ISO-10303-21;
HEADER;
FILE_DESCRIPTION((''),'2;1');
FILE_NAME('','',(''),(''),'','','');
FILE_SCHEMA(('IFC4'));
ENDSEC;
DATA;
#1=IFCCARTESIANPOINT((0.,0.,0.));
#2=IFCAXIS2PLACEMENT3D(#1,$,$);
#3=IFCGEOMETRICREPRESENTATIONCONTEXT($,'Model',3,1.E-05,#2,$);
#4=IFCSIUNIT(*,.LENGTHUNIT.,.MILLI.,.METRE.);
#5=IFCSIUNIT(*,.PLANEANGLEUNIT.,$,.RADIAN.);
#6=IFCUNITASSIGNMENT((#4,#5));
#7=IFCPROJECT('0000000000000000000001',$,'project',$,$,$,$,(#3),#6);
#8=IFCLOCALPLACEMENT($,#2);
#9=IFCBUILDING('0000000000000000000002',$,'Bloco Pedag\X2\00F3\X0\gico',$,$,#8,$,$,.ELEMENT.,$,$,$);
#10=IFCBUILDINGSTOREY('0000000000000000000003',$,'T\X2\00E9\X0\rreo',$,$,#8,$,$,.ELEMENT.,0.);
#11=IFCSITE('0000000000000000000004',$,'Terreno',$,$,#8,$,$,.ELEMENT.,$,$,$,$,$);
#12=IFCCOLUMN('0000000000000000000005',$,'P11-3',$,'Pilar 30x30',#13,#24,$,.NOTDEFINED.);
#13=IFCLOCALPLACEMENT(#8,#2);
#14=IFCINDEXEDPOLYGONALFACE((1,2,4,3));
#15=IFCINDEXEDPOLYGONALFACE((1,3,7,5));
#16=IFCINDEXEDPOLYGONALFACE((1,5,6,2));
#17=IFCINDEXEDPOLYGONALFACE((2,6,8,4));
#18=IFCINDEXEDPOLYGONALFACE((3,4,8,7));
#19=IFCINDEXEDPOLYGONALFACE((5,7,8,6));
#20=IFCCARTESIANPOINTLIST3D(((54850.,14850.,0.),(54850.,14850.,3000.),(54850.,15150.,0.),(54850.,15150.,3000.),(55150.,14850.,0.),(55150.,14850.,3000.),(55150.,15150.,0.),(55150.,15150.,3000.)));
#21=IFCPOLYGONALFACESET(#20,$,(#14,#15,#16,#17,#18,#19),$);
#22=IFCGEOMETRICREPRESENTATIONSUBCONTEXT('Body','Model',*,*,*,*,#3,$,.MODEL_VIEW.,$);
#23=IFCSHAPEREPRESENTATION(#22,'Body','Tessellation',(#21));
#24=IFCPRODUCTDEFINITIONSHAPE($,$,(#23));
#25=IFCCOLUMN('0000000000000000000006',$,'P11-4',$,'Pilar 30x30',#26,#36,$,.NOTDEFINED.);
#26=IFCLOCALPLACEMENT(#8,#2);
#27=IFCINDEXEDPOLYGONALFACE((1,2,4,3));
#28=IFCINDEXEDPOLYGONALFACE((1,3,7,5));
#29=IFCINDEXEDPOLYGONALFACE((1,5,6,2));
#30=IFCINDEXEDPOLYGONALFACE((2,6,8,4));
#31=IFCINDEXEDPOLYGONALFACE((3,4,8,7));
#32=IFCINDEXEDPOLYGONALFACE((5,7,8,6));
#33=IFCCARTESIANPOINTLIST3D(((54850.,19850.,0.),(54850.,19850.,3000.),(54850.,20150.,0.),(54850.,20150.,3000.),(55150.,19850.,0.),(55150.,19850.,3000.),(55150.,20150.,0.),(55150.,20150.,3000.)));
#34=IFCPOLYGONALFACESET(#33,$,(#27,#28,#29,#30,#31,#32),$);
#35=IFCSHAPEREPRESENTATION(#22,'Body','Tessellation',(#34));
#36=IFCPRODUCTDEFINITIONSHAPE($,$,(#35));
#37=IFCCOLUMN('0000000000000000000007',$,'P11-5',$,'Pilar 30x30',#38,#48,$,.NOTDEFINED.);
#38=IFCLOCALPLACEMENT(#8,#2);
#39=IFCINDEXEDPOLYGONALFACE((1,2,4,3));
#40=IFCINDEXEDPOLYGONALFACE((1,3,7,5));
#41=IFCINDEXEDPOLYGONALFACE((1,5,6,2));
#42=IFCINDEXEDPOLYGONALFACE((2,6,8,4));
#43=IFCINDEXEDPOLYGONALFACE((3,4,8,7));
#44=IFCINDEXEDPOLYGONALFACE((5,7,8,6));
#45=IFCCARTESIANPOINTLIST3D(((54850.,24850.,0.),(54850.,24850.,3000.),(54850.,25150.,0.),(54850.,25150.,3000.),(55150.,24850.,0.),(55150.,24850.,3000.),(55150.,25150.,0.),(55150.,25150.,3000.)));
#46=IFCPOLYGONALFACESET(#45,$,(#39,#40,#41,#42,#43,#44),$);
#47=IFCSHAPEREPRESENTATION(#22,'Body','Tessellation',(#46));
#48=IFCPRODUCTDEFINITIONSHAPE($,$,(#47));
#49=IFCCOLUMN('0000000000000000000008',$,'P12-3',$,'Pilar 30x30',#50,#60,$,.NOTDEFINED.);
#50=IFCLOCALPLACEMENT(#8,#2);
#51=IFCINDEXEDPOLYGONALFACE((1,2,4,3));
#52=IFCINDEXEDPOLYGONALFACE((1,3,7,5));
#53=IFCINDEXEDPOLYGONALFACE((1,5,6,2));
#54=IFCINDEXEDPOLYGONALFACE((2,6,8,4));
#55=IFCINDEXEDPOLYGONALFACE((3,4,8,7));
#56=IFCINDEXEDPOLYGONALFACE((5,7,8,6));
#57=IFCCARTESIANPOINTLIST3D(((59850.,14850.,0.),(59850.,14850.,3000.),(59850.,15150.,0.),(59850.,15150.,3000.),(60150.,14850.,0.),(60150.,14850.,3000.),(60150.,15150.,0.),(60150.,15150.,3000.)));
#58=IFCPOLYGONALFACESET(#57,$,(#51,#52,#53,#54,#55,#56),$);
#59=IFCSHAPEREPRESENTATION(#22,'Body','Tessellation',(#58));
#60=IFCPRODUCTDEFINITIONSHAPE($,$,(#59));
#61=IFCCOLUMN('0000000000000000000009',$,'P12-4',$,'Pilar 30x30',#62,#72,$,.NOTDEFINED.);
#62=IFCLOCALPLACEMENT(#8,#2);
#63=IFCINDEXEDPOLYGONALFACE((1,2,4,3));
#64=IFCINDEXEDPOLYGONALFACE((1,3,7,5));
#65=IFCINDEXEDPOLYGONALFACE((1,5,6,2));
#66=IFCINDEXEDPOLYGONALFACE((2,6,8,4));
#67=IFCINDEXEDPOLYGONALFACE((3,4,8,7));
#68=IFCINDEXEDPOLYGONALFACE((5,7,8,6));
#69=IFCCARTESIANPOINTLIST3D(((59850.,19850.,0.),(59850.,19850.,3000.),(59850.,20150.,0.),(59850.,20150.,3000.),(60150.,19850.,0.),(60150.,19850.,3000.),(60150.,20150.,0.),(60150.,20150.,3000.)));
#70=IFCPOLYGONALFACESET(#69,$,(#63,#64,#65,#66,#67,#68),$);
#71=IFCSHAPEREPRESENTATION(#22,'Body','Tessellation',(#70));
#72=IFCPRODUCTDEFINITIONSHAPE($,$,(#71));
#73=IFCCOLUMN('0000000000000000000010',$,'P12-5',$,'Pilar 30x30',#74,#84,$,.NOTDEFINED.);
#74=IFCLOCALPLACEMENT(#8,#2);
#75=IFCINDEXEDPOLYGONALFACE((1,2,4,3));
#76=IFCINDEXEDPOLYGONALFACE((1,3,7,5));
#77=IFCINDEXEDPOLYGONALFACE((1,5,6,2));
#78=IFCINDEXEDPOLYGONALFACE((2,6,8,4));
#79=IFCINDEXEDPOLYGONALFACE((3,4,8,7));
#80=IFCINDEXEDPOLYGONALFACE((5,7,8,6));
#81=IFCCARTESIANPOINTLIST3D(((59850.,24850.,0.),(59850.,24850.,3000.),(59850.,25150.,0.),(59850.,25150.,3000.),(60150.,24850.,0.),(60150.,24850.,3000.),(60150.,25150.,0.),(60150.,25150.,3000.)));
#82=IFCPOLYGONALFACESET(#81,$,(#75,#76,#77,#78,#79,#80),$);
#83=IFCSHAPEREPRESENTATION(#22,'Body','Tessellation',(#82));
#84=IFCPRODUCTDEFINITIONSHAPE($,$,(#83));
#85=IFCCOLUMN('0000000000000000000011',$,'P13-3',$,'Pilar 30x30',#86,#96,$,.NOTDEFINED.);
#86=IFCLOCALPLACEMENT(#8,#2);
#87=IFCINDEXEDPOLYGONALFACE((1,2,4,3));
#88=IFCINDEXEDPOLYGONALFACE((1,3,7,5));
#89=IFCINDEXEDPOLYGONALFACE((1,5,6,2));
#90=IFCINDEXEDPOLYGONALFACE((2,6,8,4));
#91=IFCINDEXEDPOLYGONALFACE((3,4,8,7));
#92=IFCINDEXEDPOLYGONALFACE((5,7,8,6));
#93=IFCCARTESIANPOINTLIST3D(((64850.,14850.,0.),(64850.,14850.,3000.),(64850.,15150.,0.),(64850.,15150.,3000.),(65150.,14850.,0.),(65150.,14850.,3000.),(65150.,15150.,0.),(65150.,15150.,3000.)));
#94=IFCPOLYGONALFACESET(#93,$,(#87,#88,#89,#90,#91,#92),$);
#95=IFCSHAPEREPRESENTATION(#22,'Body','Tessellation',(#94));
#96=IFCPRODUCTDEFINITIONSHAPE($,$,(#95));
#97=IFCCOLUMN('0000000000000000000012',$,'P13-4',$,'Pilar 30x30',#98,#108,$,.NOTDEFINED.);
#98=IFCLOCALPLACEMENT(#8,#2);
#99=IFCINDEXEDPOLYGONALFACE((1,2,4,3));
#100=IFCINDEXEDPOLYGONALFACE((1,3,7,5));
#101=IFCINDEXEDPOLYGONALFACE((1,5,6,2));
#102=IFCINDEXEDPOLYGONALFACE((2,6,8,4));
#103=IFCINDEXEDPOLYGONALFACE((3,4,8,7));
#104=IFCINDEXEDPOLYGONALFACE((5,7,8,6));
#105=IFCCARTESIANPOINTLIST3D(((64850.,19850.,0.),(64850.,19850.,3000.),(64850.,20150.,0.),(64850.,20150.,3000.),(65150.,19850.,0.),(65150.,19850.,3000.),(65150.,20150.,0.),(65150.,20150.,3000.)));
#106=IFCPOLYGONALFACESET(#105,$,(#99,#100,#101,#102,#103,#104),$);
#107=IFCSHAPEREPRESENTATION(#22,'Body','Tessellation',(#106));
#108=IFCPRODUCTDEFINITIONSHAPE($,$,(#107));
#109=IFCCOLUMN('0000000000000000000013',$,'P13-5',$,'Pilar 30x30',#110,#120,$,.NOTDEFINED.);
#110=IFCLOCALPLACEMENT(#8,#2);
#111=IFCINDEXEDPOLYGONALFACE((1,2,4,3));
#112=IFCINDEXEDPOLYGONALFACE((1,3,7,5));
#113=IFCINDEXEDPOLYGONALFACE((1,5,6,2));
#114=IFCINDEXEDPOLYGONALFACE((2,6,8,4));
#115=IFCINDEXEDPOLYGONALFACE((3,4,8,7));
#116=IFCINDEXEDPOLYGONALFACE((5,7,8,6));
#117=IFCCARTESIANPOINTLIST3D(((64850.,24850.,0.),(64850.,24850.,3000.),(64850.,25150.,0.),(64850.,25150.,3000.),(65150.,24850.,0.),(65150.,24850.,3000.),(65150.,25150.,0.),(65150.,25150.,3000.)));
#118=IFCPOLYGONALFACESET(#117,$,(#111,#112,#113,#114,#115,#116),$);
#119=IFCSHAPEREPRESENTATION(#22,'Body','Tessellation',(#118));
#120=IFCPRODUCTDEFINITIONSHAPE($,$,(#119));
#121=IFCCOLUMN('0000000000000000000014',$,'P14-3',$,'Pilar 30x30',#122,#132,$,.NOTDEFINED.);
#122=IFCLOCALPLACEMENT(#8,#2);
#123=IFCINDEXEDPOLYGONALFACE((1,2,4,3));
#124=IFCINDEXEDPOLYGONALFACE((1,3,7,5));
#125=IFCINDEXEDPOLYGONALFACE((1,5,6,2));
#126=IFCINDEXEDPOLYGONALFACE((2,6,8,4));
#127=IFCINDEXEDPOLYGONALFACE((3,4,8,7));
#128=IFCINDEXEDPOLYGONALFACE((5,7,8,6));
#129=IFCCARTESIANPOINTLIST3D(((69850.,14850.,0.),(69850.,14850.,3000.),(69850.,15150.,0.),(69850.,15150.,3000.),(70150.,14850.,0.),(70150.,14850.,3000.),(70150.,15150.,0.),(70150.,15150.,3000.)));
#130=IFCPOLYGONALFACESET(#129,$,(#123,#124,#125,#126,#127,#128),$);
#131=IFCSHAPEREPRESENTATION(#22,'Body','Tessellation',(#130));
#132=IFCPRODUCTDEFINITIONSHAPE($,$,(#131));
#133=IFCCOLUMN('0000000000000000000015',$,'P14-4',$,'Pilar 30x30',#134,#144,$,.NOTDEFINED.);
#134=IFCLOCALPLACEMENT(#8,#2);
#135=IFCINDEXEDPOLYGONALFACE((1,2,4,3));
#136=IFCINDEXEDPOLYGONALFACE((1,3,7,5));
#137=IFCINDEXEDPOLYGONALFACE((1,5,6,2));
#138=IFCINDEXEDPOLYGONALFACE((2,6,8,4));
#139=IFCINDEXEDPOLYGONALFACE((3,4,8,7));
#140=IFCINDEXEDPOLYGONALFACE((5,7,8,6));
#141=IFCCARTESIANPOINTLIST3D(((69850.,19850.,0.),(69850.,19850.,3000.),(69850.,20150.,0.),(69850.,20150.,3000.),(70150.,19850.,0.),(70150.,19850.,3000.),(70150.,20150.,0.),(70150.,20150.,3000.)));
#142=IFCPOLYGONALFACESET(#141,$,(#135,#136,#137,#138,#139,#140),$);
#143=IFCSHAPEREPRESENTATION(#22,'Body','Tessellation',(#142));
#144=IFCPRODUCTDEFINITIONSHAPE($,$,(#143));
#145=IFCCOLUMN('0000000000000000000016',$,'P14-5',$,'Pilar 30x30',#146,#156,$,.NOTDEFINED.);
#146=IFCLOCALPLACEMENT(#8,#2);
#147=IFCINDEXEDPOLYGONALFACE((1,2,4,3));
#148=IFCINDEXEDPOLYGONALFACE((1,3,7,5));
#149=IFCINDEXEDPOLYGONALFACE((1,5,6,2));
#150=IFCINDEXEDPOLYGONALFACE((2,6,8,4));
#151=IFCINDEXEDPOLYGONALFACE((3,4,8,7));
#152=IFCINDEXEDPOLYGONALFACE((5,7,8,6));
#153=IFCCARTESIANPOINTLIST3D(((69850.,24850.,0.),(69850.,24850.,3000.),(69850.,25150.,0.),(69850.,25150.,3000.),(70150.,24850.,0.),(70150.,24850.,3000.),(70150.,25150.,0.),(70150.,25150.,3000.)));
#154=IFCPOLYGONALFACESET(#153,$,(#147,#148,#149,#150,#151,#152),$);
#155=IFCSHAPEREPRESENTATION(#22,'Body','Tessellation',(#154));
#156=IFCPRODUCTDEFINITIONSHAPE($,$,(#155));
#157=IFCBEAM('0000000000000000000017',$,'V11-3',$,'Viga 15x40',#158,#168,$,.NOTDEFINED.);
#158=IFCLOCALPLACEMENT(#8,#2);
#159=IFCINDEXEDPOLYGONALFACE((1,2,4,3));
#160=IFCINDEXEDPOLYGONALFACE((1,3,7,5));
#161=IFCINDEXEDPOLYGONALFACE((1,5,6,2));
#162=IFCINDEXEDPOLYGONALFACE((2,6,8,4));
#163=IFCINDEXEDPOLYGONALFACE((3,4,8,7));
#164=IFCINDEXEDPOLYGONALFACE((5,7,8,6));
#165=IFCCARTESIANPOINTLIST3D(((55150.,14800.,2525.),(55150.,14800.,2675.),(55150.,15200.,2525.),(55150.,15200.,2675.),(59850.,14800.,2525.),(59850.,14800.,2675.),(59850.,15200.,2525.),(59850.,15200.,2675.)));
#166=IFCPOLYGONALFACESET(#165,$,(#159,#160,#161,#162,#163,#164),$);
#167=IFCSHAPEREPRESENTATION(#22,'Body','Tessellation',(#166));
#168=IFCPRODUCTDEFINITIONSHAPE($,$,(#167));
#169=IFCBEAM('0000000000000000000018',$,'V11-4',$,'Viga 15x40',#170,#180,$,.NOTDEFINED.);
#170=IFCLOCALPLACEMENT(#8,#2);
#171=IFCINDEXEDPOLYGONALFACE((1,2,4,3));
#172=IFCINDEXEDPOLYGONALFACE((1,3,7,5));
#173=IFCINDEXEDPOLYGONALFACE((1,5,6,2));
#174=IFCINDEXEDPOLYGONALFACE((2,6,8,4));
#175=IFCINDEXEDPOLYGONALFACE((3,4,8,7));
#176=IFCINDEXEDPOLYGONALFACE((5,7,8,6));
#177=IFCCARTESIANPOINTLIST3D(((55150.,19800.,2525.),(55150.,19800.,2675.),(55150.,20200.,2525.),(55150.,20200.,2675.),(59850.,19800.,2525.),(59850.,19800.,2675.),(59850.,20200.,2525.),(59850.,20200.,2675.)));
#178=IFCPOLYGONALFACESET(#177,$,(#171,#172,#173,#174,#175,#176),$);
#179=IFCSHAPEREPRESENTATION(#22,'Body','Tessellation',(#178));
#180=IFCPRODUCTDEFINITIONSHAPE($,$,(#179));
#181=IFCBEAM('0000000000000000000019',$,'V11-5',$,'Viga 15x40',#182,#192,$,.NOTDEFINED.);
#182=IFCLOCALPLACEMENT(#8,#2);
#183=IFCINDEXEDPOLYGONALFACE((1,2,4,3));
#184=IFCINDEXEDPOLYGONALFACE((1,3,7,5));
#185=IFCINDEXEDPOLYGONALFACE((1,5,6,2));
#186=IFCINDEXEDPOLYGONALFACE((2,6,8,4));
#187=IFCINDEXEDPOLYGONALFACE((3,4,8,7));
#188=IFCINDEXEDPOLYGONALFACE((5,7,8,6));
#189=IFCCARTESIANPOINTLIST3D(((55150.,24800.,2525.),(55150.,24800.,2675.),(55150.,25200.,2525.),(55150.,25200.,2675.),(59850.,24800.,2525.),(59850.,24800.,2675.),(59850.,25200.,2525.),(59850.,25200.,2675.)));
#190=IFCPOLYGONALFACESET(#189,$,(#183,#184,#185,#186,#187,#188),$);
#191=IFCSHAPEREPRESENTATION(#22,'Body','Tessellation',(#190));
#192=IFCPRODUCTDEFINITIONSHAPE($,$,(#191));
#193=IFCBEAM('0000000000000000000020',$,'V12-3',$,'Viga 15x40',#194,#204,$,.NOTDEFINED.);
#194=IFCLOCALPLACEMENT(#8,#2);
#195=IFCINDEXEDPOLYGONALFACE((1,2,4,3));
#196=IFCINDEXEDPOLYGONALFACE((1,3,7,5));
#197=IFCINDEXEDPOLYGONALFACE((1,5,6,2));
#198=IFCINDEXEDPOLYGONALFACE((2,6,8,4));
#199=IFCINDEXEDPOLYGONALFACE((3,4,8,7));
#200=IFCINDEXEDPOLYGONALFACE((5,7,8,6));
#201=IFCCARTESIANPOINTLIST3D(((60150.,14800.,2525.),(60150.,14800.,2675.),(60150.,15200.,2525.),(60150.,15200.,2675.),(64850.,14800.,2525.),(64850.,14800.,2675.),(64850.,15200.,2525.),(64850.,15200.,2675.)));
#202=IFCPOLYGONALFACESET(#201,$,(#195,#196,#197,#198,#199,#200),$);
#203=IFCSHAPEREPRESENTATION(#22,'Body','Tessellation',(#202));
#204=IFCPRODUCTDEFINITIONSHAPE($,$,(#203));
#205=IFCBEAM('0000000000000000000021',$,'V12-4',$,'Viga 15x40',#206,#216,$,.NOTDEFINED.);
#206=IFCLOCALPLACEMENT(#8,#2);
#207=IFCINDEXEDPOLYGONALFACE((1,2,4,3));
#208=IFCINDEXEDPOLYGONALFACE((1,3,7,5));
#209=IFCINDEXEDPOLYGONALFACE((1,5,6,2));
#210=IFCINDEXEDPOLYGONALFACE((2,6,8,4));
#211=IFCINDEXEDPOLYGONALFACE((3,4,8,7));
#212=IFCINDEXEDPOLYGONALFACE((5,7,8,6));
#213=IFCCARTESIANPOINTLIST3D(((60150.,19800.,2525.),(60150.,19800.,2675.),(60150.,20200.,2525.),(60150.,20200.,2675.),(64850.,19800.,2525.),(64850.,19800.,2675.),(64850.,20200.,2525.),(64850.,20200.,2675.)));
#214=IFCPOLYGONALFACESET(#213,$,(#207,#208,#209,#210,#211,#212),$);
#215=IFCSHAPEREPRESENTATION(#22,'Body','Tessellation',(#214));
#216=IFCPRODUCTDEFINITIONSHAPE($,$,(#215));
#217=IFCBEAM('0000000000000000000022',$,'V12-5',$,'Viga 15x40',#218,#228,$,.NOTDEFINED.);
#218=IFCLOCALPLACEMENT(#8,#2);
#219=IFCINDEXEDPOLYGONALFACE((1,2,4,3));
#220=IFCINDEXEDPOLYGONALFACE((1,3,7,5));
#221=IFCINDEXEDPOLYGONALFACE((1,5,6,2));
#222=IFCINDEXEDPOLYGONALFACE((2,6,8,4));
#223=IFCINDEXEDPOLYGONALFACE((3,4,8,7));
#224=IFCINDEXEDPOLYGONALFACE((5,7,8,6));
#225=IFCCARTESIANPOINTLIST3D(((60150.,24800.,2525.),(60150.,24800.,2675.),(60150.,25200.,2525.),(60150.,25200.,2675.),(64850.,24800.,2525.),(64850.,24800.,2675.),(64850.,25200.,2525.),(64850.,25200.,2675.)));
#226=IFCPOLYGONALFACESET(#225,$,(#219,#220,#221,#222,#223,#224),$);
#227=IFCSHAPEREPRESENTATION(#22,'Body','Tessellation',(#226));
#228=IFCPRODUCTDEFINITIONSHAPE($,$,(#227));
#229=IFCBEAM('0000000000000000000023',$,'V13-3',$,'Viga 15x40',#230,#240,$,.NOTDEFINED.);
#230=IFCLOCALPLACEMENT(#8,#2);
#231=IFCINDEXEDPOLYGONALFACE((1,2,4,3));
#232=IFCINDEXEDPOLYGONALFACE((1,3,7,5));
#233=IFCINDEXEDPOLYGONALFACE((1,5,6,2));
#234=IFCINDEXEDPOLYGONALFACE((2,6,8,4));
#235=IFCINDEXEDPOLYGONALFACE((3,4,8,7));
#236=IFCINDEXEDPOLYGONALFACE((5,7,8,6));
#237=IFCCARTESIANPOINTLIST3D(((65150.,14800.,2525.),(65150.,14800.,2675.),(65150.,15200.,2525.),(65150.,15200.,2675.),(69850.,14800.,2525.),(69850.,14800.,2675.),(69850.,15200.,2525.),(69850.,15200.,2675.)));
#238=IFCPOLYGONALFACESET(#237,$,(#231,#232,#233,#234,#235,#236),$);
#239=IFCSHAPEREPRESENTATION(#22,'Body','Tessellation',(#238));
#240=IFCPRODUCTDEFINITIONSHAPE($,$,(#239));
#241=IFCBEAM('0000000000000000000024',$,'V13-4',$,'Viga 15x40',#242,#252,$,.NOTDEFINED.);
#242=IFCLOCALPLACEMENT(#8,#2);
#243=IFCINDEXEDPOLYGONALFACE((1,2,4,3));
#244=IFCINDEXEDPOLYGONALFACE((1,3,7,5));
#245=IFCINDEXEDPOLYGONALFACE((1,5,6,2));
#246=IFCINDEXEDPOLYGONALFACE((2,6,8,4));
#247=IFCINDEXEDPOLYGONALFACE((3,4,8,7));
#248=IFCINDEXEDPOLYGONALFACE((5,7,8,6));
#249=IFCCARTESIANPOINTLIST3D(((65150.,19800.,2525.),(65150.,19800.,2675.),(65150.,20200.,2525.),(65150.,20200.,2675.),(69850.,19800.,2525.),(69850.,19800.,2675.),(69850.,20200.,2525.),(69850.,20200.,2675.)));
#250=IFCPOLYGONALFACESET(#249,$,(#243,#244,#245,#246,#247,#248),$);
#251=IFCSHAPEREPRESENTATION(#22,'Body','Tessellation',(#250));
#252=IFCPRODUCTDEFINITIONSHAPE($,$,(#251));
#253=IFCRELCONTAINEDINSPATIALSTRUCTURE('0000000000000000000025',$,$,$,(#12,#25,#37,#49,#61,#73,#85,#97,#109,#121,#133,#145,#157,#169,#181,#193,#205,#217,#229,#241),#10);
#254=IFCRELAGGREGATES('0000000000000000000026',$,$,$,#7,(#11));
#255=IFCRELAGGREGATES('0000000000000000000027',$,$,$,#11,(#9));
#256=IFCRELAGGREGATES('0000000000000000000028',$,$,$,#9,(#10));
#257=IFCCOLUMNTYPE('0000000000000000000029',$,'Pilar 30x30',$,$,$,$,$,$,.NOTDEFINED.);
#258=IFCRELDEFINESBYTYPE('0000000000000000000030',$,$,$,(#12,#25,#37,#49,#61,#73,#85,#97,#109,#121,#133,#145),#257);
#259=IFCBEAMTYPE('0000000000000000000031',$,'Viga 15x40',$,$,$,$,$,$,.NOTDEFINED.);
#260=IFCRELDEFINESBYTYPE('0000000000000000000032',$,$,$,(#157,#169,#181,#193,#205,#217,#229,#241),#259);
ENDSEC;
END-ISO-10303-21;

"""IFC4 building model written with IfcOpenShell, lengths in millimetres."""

from ifc_helpers import new_model, si_unit, frame, origin, origin_2d, place, context, subcontext, project, spatial, rectangle, extrude, type_object, element, save


model = new_model("IFC4")

# Units and contexts
model_context = context("Model", 3, precision=1e-05, world=origin())
body_context = subcontext(model_context, "Body", "Model", "MODEL_VIEW")
ifc_project = project(units=[si_unit("LENGTHUNIT", "METRE", prefix="MILLI"), si_unit("PLANEANGLEUNIT", "RADIAN")], contexts=[model_context])

# Site, building, storey
placement = place(None, origin())
site = spatial("IfcSite", under=ifc_project, at=placement, Name="Terreno", CompositionType="ELEMENT")
building = spatial("IfcBuilding", under=site, at=placement, Name="Bloco Pedagógico", CompositionType="ELEMENT")
storey = spatial("IfcBuildingStorey", under=building, at=placement, Name="Térreo", CompositionType="ELEMENT", Elevation=0.0)

# Columns
column_type = type_object("IfcColumnType", Name="Pilar 30x30", PredefinedType="NOTDEFINED")
for number, where, z_axis, x_axis, name in (
    (1, (55000.0, 15000.0, 0.0), (0.0, 0.0, 1.0), (1.0, 0.0, 0.0), "P11-3"),
    (2, (55000.0, 20000.0, 0.0), (0.0, 0.0, 1.0), (1.0, 0.0, 0.0), "P11-4"),
    (3, (55000.0, 25000.0, 0.0), (0.0, 0.0, 1.0), (1.0, 0.0, 0.0), "P11-5"),
    (4, (60000.0, 15000.0, 0.0), (0.0, 0.0, 1.0), (1.0, 0.0, 0.0), "P12-3"),
    (5, (60000.0, 20000.0, 0.0), (0.0, 0.0, 1.0), (1.0, 0.0, 0.0), "P12-4"),
    (6, (60000.0, 25000.0, 0.0), (0.0, 0.0, 1.0), (1.0, 0.0, 0.0), "P12-5"),
    (7, (65000.0, 15000.0, 0.0), (0.0, 0.0, 1.0), (1.0, 0.0, 0.0), "P13-3"),
    (8, (65000.0, 20000.0, 0.0), (0.0, 0.0, 1.0), (1.0, 0.0, 0.0), "P13-4"),
    (9, (65000.0, 25000.0, 0.0), (0.0, 0.0, 1.0), (1.0, 0.0, 0.0), "P13-5"),
    (10, (70000.0, 15000.0, 0.0), (0.0, 0.0, 1.0), (1.0, 0.0, 0.0), "P14-3"),
    (11, (70000.0, 20000.0, 0.0), (0.0, 0.0, 1.0), (1.0, 0.0, 0.0), "P14-4"),
    (12, (70000.0, 25000.0, 0.0), (0.0, 0.0, 1.0), (1.0, 0.0, 0.0), "P14-5"),
):
    element("IfcColumn", number, at=place(None, frame(where, z_axis=z_axis, x_axis=x_axis)), inside=storey, type_object=column_type, Name=name, ObjectType="Pilar 30x30", PredefinedType="NOTDEFINED", context=body_context, shape_type="SweptSolid", body=[
        extrude(rectangle(XDim=300.0, YDim=300.0, at=origin_2d()), None, (0.0, 0.0, 1.0), 3000.0),
    ])

# Beams
beam_type = type_object("IfcBeamType", Name="Viga 15x40", PredefinedType="NOTDEFINED")
for number, where, z_axis, x_axis, name in (
    (13, (55150.0, 15000.0, 2600.0), (1.0, 0.0, 0.0), (0.0, 1.0, 0.0), "V11-3"),
    (14, (55150.0, 20000.0, 2600.0), (1.0, 0.0, 0.0), (0.0, 1.0, 0.0), "V11-4"),
    (15, (55150.0, 25000.0, 2600.0), (1.0, 0.0, 0.0), (0.0, 1.0, 0.0), "V11-5"),
    (16, (60150.0, 15000.0, 2600.0), (1.0, 0.0, 0.0), (0.0, 1.0, 0.0), "V12-3"),
    (17, (60150.0, 20000.0, 2600.0), (1.0, 0.0, 0.0), (0.0, 1.0, 0.0), "V12-4"),
    (18, (60150.0, 25000.0, 2600.0), (1.0, 0.0, 0.0), (0.0, 1.0, 0.0), "V12-5"),
    (19, (65150.0, 15000.0, 2600.0), (1.0, 0.0, 0.0), (0.0, 1.0, 0.0), "V13-3"),
    (20, (65150.0, 20000.0, 2600.0), (1.0, 0.0, 0.0), (0.0, 1.0, 0.0), "V13-4"),
):
    element("IfcBeam", number, at=place(None, frame(where, z_axis=z_axis, x_axis=x_axis)), inside=storey, type_object=beam_type, Name=name, ObjectType="Viga 15x40", PredefinedType="NOTDEFINED", context=body_context, shape_type="SweptSolid", body=[
        extrude(rectangle(XDim=400.0, YDim=150.0, at=origin_2d()), None, (0.0, 0.0, 1.0), 4700.0),
    ])

save(model, "model.ifc")
